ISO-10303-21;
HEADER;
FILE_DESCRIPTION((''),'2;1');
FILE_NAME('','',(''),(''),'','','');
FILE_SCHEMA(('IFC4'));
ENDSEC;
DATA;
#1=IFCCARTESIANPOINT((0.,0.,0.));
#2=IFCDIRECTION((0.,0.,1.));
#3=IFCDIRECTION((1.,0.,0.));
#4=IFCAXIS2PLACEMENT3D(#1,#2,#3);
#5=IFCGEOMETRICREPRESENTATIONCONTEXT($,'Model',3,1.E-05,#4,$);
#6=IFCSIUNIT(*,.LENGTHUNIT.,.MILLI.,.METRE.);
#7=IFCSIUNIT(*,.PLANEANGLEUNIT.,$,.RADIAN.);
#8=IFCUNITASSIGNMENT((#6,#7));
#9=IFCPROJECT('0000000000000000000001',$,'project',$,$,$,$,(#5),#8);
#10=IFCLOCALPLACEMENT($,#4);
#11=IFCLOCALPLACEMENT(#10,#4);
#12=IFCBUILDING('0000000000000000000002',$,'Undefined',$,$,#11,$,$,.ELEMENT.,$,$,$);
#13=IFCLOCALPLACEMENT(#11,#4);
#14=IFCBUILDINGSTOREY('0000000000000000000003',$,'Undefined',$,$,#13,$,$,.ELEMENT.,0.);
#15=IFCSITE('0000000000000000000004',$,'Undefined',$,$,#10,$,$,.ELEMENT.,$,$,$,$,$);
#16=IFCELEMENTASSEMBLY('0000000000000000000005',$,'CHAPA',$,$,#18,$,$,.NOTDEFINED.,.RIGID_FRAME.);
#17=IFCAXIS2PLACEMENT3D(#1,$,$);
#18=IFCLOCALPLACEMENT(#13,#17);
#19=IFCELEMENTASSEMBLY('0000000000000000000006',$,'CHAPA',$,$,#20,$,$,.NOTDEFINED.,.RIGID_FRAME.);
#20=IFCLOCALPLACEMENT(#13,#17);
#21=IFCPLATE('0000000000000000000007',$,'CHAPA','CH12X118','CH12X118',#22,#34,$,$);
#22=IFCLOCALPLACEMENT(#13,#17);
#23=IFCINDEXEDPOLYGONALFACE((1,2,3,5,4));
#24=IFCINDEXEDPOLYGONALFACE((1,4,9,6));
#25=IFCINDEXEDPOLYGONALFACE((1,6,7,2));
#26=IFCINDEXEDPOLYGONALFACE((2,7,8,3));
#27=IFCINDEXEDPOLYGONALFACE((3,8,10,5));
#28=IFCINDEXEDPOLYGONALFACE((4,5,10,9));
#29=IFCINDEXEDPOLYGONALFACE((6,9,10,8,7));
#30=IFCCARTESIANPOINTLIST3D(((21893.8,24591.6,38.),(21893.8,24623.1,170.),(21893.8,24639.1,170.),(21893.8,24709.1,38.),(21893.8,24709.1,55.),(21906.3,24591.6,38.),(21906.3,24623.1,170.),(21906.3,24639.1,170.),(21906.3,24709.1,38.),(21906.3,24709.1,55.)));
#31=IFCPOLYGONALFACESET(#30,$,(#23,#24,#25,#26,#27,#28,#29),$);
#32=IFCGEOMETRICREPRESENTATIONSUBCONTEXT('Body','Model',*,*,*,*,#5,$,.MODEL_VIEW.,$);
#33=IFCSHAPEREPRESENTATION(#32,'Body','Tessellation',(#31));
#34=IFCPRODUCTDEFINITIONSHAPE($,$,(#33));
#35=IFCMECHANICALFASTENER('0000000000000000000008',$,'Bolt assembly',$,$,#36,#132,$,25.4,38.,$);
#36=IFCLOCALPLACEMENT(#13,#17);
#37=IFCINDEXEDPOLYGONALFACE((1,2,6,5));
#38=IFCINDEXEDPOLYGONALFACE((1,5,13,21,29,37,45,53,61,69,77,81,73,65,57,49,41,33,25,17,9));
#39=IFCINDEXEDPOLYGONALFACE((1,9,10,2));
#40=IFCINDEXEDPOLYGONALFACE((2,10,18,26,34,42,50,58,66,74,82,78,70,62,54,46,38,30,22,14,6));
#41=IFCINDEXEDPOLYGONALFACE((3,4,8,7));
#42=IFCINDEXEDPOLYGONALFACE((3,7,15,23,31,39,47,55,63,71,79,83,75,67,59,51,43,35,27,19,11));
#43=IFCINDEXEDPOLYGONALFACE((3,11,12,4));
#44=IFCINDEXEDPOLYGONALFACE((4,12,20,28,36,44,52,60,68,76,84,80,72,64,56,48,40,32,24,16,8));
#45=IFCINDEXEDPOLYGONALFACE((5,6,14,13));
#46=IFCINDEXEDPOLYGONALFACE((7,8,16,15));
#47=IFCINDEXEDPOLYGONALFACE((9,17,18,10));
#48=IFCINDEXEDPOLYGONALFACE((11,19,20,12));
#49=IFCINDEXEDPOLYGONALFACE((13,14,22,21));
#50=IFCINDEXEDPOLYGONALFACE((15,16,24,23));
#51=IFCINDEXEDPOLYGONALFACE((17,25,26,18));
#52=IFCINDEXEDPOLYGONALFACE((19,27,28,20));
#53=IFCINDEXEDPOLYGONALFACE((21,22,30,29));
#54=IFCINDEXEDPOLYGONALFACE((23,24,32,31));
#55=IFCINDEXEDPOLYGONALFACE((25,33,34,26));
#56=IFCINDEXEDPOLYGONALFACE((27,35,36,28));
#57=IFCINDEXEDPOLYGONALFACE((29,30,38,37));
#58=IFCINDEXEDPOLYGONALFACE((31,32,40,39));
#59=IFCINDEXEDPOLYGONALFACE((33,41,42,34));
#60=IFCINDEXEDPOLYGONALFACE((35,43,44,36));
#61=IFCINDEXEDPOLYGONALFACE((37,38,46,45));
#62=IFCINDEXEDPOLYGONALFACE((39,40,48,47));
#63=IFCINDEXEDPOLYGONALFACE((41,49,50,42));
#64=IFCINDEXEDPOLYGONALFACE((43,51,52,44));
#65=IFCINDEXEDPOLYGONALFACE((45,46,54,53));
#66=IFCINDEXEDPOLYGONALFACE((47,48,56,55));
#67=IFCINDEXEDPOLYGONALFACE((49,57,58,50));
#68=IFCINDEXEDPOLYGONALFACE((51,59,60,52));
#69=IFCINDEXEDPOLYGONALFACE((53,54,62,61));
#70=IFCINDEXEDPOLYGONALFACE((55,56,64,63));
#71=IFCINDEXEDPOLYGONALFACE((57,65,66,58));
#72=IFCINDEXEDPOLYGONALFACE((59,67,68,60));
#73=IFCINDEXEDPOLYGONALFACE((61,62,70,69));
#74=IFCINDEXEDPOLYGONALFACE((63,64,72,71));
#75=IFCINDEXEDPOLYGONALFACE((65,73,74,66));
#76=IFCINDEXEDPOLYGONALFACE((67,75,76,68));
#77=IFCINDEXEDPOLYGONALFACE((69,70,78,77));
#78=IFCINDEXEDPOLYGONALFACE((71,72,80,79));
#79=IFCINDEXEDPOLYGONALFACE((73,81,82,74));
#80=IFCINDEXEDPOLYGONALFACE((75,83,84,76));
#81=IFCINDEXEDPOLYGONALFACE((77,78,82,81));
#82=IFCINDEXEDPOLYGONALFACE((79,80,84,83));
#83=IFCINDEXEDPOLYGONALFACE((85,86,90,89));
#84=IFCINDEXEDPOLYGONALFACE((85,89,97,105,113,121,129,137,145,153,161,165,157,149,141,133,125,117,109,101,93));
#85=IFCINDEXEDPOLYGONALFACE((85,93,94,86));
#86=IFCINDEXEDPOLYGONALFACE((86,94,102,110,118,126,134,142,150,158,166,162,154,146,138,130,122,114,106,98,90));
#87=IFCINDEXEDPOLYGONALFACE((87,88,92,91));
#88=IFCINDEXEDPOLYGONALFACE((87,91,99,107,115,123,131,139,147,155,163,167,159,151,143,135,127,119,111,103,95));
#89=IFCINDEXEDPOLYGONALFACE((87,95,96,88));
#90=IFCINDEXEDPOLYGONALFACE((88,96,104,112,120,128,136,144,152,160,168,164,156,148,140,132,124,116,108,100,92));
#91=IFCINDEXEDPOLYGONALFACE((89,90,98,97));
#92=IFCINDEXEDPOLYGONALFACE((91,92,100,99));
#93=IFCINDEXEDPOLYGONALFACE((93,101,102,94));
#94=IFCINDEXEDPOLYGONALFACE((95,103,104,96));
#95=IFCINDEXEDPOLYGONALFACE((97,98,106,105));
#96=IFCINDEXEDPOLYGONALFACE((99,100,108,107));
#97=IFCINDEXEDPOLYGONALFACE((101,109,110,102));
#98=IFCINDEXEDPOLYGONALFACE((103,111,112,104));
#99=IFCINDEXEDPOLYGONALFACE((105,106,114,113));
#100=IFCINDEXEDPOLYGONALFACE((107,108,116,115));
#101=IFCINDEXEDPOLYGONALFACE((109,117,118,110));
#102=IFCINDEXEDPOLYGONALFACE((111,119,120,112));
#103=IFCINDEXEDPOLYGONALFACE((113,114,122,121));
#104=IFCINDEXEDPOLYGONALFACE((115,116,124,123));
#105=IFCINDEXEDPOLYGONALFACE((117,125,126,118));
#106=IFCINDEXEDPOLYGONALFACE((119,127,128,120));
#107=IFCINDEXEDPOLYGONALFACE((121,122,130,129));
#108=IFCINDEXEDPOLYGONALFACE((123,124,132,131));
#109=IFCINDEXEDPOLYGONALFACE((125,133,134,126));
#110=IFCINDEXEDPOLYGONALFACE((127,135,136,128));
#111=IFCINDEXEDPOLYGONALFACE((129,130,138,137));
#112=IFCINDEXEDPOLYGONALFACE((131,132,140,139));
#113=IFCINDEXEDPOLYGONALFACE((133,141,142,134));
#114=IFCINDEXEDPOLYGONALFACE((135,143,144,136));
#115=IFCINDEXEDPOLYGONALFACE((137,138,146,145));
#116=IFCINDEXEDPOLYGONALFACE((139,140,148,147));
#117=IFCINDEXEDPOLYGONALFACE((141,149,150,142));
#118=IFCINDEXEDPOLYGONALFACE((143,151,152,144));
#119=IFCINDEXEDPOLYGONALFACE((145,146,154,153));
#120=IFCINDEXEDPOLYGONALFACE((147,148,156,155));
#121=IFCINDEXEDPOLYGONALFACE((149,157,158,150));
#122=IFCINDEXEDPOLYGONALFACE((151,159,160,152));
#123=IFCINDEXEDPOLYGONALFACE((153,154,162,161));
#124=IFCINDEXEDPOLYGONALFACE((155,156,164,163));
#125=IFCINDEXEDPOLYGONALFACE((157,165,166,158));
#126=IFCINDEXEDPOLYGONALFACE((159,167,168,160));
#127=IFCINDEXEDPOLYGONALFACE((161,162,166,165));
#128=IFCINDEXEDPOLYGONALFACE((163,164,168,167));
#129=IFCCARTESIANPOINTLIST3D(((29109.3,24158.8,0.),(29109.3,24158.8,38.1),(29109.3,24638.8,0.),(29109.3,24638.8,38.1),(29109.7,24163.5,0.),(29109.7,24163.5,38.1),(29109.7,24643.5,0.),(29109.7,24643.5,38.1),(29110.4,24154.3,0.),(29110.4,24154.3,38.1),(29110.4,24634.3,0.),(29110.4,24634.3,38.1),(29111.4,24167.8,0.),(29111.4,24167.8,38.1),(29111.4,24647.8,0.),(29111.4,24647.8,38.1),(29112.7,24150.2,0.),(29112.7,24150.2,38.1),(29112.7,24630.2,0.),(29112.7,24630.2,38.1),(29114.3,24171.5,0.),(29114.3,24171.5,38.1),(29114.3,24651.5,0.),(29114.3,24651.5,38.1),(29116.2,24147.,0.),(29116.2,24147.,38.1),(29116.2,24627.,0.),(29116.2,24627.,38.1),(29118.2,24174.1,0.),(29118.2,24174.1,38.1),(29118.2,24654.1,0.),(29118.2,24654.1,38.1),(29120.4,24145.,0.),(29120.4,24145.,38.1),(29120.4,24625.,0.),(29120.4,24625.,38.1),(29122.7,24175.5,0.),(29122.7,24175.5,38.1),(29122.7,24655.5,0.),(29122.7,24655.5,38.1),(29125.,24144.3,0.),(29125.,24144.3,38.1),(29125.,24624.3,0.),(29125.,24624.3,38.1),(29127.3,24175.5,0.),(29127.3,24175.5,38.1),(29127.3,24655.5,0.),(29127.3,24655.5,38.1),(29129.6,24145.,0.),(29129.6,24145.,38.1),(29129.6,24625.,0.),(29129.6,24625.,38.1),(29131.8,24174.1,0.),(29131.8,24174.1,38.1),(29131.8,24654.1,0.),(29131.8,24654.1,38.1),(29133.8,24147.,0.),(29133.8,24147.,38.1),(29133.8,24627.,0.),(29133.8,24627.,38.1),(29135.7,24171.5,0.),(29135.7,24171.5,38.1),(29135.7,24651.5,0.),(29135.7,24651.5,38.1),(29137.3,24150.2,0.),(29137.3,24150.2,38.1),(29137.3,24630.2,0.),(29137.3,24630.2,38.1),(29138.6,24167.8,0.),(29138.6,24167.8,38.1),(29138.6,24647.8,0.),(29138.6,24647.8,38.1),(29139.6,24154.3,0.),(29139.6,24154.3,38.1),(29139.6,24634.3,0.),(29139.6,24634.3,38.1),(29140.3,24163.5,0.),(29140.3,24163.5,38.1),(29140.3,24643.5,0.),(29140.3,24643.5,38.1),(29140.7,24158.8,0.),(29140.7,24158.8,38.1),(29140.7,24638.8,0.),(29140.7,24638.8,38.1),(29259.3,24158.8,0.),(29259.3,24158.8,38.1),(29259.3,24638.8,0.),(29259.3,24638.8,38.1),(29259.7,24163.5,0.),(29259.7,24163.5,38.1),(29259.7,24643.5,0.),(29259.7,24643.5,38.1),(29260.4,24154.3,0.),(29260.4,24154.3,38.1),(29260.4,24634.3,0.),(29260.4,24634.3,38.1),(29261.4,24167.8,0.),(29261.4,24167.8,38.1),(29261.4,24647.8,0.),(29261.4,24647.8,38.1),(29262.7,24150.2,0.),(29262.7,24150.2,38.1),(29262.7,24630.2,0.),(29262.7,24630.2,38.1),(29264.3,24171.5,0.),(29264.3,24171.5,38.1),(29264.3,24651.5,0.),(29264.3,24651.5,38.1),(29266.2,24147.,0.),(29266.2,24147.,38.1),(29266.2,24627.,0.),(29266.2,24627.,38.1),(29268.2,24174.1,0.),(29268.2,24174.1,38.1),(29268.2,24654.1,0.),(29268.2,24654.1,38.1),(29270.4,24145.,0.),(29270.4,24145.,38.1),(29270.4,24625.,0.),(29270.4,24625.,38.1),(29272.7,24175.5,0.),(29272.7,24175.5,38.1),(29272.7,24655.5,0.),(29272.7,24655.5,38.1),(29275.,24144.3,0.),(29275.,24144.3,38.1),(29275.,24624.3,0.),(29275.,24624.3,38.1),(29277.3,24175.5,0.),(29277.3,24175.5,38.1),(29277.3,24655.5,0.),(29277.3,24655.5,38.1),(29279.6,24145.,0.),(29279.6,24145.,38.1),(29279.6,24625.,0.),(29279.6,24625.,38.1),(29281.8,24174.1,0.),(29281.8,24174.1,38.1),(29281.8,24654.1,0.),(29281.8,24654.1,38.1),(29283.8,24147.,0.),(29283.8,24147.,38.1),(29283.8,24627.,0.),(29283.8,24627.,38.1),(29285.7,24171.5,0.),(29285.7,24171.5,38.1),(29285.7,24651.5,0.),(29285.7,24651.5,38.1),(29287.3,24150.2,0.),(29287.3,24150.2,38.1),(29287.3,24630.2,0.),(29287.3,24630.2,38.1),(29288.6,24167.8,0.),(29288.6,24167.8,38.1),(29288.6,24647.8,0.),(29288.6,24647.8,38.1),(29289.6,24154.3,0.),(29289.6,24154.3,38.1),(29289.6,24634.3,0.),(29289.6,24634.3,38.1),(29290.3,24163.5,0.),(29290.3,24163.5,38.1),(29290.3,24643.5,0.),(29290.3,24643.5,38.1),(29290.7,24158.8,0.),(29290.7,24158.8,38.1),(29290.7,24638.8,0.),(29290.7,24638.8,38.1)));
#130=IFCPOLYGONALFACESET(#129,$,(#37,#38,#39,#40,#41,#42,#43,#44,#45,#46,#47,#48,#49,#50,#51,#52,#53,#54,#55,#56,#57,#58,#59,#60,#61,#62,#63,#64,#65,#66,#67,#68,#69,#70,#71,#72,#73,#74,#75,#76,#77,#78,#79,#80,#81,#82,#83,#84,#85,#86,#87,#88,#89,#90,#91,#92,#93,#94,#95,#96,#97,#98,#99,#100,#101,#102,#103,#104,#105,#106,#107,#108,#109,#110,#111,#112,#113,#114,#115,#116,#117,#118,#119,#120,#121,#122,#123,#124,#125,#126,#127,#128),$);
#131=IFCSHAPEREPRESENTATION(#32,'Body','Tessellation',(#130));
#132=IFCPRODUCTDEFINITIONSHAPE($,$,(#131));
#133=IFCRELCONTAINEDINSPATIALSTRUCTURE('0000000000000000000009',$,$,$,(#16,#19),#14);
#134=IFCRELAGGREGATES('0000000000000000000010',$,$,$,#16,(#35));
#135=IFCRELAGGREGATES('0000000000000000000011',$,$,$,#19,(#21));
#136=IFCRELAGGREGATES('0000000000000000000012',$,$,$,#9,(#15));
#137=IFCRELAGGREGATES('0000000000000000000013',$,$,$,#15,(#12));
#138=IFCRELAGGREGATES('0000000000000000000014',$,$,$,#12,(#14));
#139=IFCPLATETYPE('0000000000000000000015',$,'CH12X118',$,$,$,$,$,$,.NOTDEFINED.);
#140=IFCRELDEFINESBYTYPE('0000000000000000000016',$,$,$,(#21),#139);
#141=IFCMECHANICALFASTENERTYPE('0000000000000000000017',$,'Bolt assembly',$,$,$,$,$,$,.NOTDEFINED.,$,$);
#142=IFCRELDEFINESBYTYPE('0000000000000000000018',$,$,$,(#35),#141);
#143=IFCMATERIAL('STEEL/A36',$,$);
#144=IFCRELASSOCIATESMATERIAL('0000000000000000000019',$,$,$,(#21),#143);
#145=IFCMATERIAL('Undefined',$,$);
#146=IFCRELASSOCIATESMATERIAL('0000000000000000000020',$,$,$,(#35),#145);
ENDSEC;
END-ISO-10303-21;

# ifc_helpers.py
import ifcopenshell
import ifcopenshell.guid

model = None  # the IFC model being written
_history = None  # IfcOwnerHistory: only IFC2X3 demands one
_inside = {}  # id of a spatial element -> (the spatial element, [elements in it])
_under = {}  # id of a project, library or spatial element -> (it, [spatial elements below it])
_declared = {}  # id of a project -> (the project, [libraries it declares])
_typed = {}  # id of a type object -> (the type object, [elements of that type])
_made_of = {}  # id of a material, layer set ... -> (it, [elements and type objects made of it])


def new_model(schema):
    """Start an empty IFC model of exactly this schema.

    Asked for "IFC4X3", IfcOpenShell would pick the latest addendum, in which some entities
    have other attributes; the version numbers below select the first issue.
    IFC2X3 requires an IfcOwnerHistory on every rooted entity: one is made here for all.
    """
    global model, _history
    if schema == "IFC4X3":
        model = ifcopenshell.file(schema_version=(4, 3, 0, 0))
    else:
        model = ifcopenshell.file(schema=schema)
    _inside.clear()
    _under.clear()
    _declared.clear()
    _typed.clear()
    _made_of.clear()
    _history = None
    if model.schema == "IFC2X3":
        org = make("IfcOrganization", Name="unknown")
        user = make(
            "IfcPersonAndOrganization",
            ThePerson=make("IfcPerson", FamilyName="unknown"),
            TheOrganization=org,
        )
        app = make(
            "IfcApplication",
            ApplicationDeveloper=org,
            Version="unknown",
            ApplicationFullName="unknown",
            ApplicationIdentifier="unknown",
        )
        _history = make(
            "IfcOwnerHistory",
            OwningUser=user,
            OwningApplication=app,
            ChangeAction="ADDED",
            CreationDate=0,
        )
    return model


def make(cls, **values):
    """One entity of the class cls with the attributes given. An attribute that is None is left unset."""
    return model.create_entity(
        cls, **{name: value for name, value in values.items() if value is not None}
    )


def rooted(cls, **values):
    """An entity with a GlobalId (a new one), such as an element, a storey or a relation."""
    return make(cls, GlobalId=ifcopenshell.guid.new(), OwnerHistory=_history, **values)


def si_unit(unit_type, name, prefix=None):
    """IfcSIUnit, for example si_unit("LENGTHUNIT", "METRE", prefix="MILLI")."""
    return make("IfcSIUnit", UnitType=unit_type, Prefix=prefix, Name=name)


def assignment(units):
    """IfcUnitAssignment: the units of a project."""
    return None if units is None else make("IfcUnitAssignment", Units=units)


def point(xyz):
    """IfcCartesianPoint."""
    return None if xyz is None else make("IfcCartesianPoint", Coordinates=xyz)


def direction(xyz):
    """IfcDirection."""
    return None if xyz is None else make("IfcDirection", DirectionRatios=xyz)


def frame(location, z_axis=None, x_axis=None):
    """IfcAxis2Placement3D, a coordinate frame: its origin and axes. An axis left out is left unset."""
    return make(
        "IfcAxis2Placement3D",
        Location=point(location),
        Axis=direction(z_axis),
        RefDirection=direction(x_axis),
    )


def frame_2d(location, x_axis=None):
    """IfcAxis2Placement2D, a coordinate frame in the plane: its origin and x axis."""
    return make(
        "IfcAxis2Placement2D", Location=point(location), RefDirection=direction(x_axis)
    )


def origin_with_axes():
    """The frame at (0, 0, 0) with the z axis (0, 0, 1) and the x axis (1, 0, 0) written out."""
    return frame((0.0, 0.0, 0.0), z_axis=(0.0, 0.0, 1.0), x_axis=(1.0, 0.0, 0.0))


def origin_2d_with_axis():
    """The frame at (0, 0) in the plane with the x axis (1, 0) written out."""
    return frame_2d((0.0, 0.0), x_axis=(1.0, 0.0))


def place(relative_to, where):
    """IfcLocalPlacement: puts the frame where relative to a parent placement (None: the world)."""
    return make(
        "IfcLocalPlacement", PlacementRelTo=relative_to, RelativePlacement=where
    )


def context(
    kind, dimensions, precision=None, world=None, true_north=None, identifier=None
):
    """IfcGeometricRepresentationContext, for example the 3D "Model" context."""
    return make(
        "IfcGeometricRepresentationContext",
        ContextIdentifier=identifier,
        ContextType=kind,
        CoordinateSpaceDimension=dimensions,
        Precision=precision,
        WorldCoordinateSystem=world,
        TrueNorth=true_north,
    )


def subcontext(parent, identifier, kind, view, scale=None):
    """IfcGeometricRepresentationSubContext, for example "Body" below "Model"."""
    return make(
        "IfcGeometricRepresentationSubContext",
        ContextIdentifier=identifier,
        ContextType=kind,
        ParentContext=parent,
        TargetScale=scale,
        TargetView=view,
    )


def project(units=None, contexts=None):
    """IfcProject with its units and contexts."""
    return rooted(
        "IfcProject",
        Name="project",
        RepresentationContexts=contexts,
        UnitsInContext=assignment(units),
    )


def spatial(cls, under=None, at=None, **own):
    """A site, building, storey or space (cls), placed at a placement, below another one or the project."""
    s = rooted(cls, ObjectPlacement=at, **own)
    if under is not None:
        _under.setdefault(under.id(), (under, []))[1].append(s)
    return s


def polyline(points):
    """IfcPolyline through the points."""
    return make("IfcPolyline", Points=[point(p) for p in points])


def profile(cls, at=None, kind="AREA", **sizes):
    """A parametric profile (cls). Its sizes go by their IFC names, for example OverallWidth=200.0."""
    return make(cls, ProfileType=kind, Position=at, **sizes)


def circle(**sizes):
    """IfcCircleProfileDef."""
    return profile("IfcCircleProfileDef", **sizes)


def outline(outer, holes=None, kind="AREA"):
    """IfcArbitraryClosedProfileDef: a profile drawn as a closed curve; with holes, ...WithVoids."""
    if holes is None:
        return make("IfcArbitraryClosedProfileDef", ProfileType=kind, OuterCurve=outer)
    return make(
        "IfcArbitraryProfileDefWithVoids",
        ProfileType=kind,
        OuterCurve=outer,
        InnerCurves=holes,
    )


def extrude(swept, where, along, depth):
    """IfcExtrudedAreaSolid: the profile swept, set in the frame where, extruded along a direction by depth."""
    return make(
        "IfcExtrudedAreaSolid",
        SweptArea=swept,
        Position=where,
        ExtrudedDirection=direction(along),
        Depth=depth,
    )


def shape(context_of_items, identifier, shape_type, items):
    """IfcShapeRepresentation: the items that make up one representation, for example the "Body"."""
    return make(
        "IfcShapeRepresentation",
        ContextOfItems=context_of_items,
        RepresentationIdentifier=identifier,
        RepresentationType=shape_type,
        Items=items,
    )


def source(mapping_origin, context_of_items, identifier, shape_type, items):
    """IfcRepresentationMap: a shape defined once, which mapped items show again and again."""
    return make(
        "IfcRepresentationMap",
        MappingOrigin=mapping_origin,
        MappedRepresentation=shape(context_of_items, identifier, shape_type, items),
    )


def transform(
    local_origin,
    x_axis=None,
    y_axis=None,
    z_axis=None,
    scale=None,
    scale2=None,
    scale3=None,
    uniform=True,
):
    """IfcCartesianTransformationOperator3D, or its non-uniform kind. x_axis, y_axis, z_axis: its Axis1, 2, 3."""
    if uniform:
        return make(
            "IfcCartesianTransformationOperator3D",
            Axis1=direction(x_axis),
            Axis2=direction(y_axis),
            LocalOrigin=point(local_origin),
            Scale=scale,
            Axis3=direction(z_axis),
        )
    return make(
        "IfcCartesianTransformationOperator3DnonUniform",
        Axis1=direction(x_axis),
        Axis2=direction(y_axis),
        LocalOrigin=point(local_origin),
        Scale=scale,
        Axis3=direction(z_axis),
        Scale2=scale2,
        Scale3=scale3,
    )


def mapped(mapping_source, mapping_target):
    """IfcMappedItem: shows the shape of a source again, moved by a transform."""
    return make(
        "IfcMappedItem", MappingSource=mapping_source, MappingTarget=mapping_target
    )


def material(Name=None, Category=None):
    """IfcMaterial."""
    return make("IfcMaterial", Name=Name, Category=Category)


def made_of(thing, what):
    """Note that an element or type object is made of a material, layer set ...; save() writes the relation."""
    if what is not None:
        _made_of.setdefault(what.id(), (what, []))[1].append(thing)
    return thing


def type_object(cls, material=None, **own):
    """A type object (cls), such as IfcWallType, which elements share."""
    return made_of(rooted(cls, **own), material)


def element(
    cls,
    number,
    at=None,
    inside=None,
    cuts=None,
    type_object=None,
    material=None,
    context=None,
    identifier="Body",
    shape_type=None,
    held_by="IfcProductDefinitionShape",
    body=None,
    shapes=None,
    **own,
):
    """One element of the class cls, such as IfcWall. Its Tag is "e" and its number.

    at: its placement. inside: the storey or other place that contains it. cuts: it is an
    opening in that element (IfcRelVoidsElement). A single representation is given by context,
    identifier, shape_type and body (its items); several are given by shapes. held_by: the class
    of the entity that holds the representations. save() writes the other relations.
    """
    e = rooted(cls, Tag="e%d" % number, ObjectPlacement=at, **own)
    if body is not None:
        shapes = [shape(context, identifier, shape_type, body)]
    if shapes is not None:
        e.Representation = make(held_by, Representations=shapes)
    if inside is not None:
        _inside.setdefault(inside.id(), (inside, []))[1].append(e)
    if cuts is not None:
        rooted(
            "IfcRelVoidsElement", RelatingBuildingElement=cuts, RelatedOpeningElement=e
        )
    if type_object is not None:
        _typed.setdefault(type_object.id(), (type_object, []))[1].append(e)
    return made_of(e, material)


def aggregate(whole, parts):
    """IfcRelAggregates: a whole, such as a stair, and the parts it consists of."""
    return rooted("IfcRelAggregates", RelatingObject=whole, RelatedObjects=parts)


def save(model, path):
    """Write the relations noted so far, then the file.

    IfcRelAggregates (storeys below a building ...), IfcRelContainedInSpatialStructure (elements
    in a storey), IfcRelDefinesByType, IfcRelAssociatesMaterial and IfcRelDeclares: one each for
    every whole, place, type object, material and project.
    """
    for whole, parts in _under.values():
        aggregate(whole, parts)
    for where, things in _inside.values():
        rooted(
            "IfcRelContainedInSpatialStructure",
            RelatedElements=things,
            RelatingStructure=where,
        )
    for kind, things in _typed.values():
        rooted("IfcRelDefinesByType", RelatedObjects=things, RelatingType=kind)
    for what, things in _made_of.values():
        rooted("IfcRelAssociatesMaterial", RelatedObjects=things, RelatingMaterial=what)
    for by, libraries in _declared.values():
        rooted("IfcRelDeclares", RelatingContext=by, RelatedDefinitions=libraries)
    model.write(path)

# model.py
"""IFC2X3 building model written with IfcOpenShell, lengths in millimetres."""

from ifc_helpers import new_model, si_unit, frame, origin_with_axes, origin_2d_with_axis, place, context, subcontext, project, spatial, polyline, circle, outline, extrude, source, transform, mapped, material, type_object, element, aggregate, save


model = new_model("IFC2X3")

# Units and contexts
model_context = context("Model", 3, precision=1e-05, world=origin_with_axes())
body_context = subcontext(model_context, "Body", "Model", "MODEL_VIEW")
ifc_project = project(units=[si_unit("LENGTHUNIT", "METRE", prefix="MILLI"), si_unit("PLANEANGLEUNIT", "RADIAN")], contexts=[model_context])

# Site, building, storey
site_placement = place(None, origin_with_axes())
site = spatial("IfcSite", under=ifc_project, at=site_placement, Name="Undefined", CompositionType="ELEMENT")
building_placement = place(site_placement, origin_with_axes())
building = spatial("IfcBuilding", under=site, at=building_placement, Name="Undefined", CompositionType="ELEMENT")
storey_placement = place(building_placement, origin_with_axes())
storey = spatial("IfcBuildingStorey", under=building, at=storey_placement, Name="Undefined", CompositionType="ELEMENT", Elevation=0.0)

# Element assemblies
assembly_1_placement = place(storey_placement, origin_with_axes())
assembly_1 = element("IfcElementAssembly", 1, at=assembly_1_placement, inside=storey, Name="CHAPA", AssemblyPlace="NOTDEFINED", PredefinedType="RIGID_FRAME")
assembly_2_placement = place(storey_placement, origin_with_axes())
assembly_2 = element("IfcElementAssembly", 2, at=assembly_2_placement, inside=storey, Name="CHAPA", AssemblyPlace="NOTDEFINED", PredefinedType="RIGID_FRAME")

# Shared definitions
ifc_material_1 = material(Name="STEEL/A36")

# Plate
plate_type_1 = type_object("IfcPlateType", Name="CH12X118", PredefinedType="NOTDEFINED")
plate_1_placement = place(assembly_2_placement, frame((21900.0, 24709.1, 38.0), z_axis=(-1.0, 0.0, 0.0), x_axis=(0.0, -1.0, 0.0)))
plate_1 = element("IfcPlate", 3, at=plate_1_placement, type_object=plate_type_1, material=ifc_material_1, Name="CHAPA", Description="CH12X118", ObjectType="CH12X118", context=body_context, shape_type="SweptSolid", body=[
    extrude(outline(polyline([(0.0, 0.0), (117.5, 0.0), (85.9, 132.0), (70.0, 132.0), (0.0, 17.0), (0.0, 0.0)])), frame((0.0, 0.0, -6.2), z_axis=(0.0, 0.0, 1.0), x_axis=(1.0, 0.0, 0.0)), (0.0, 0.0, 1.0), 12.5),
])

# Shared definitions
ifc_material_2 = material(Name="Undefined")
mechanical_fastener_type = type_object("IfcMechanicalFastenerType", Name="Bolt assembly")

# Mechanical fastener
shared_shape_1 = source(origin_with_axes(), body_context, "Body", "SweptSolid", [
    extrude(circle(Radius=15.7, at=origin_2d_with_axis()), frame((0.0, -38.0, 0.0), z_axis=(0.0, 1.0, 0.0), x_axis=(1.0, 0.0, 0.0)), (0.0, 0.0, 1.0), 38.1),
])
mechanical_fastener_1_placement = place(assembly_1_placement, frame((29200.0, 24640.0, 38.0), z_axis=(-1.0, 0.0, 0.0), x_axis=(0.0, -1.0, 0.0)))
mechanical_fastener_1 = element("IfcMechanicalFastener", 4, at=mechanical_fastener_1_placement, type_object=mechanical_fastener_type, material=ifc_material_2, Name="Bolt assembly", NominalDiameter=25.4, NominalLength=38.0, context=body_context, shape_type="MappedRepresentation", body=[
    mapped(shared_shape_1, transform((0.0, 0.0, -75.0))),
    mapped(shared_shape_1, transform((0.0, 0.0, 75.0))),
    mapped(shared_shape_1, transform((480.0, 0.0, -75.0))),
    mapped(shared_shape_1, transform((480.0, 0.0, 75.0))),
])
aggregate(assembly_1, [mechanical_fastener_1])
aggregate(assembly_2, [plate_1])

save(model, "model.ifc")
